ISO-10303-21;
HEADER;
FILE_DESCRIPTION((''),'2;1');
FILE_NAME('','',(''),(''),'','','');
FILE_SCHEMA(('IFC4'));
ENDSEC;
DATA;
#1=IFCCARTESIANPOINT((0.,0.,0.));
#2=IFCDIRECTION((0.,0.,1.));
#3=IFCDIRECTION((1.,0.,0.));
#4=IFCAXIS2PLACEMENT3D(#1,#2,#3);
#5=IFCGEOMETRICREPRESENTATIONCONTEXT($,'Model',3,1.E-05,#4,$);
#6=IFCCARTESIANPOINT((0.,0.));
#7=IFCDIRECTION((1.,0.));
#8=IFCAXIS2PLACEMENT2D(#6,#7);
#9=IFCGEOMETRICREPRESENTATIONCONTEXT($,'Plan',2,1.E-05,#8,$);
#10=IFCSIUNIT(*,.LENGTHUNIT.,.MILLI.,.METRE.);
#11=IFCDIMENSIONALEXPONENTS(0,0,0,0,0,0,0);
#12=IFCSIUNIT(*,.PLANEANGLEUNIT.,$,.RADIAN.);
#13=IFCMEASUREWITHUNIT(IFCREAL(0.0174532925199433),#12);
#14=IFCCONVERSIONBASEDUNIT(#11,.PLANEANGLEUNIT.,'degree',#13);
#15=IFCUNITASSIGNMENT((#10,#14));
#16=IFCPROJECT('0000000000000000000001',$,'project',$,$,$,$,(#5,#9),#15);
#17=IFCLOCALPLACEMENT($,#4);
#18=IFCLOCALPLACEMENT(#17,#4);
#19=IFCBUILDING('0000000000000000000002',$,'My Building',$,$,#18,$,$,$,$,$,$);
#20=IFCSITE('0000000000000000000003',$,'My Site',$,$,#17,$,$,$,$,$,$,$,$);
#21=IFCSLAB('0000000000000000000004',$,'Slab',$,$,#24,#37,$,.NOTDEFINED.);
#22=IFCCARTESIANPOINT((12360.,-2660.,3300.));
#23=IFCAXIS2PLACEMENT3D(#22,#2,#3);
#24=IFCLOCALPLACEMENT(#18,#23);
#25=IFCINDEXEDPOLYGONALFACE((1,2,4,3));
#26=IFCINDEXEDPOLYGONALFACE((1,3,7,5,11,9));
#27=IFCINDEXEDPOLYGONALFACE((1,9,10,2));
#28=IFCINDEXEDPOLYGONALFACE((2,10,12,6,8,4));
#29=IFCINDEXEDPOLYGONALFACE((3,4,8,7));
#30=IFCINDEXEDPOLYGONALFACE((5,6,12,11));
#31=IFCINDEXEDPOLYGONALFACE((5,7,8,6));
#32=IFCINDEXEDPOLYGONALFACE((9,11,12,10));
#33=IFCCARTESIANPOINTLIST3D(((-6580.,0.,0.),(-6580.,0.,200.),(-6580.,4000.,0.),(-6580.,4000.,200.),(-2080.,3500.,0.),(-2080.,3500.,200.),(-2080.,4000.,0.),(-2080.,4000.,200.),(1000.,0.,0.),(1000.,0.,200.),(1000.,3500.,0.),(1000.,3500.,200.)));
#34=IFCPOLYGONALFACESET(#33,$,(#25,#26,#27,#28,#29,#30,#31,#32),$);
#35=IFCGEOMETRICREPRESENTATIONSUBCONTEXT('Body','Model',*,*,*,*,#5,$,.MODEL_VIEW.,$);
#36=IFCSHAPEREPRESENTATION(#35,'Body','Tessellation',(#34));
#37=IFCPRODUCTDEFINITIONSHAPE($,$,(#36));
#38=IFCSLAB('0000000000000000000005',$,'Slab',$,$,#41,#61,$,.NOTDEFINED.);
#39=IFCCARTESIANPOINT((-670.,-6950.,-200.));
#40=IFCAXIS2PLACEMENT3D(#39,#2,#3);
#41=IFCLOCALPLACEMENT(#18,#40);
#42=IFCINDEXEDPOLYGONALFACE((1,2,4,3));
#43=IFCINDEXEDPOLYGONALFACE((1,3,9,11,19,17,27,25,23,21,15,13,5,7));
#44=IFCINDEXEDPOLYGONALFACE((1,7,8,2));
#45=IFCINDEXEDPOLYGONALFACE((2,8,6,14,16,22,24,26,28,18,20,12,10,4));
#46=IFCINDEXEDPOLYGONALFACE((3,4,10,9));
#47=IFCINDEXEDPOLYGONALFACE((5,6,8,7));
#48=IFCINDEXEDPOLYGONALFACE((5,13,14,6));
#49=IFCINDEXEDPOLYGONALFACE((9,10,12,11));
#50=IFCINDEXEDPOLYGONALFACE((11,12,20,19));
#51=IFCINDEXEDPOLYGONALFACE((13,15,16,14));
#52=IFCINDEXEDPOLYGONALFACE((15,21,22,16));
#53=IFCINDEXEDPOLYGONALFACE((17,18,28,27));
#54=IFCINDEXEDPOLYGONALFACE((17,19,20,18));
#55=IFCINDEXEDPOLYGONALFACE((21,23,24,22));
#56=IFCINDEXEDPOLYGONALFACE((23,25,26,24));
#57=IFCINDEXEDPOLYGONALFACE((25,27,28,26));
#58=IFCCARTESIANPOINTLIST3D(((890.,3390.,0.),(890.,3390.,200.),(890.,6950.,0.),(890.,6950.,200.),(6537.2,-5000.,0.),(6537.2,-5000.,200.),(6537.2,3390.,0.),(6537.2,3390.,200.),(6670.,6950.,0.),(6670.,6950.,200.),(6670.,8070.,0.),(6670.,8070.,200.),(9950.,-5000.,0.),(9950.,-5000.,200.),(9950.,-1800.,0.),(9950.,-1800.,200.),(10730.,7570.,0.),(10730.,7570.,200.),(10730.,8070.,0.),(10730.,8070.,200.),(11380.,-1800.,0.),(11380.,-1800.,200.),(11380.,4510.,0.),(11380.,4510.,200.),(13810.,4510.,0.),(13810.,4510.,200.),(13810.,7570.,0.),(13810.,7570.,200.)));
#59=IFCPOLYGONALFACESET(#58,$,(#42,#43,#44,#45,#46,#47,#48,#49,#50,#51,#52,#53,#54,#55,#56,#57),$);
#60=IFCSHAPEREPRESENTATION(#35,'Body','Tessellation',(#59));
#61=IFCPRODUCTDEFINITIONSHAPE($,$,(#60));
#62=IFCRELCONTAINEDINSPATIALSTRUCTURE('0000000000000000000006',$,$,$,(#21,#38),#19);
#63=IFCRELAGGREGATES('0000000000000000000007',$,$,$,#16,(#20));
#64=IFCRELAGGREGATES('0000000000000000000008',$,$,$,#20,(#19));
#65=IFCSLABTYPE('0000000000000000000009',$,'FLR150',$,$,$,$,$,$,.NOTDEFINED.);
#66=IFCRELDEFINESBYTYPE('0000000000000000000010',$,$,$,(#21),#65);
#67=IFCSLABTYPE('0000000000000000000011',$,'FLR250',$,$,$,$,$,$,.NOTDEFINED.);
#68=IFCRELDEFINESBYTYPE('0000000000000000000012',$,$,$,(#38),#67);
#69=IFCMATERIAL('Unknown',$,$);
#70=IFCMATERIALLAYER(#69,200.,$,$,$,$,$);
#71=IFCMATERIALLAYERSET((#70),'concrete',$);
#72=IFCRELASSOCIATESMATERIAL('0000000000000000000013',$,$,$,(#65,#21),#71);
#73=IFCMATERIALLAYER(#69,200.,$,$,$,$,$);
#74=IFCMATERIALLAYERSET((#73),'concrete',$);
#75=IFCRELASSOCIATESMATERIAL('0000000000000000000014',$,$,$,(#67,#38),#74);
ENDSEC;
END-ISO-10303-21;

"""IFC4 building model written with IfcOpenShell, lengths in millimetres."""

from ifc_helpers import new_model, entity, si_unit, converted_unit, frame, origin_with_axes, origin_2d_with_axis, place, context, subcontext, project, spatial, line, indexed_curve, outline, extrude, material, layer, layer_set, layer_usage, type_object, element, save


model = new_model("IFC4")

# Units and contexts
model_context = context("Model", 3, precision=1e-05, world=origin_with_axes())
plan_context = context("Plan", 2, precision=1e-05, world=origin_2d_with_axis())
body_context_1 = subcontext(model_context, "Body", "Model", "MODEL_VIEW")
ifc_project = project(units=[si_unit("LENGTHUNIT", "METRE", prefix="MILLI"), converted_unit("PLANEANGLEUNIT", "degree", entity("IfcReal", 0.0174532925199433), si_unit("PLANEANGLEUNIT", "RADIAN"), dimensions=[0, 0, 0, 0, 0, 0, 0])], contexts=[model_context, plan_context])

# Site, building
site_placement = place(None, origin_with_axes())
site = spatial("IfcSite", under=ifc_project, at=site_placement, Name="My Site")
building_placement = place(site_placement, origin_with_axes())
building = spatial("IfcBuilding", under=site, at=building_placement, Name="My Building")

# Slabs
ifc_material_1 = material(Name="Unknown")
ifc_layer_1 = layer(ifc_material_1, 200.0)
ifc_layer_set_1 = layer_set([ifc_layer_1], Name="concrete")
ifc_layer_usage_1 = layer_usage(ifc_layer_set_1, "AXIS3", "POSITIVE", 0.0)
slab_type_1 = type_object("IfcSlabType", Name="FLR150", PredefinedType="NOTDEFINED", material=ifc_layer_set_1)
slab_1_placement = place(building_placement, frame((12360.0, -2660.0, 3300.0), z_axis=(0.0, 0.0, 1.0), x_axis=(1.0, 0.0, 0.0)))
element("IfcSlab", 1, at=slab_1_placement, inside=building, type_object=slab_type_1, material=ifc_layer_usage_1, Name="Slab", PredefinedType="NOTDEFINED", context=body_context_1, shape_type="SweptSolid", body=[
    extrude(outline(indexed_curve([(-6580.0, 0.0), (1000.0, 0.0), (1000.0, 3500.0), (-6580.0, 4000.0), (-2080.0, 3500.0), (-2080.0, 4000.0)], segments=[line(6, 5), line(5, 3), line(3, 2), line(2, 1), line(1, 4), line(4, 6)], self_intersect=False)), None, (0.0, 0.0, 1.0), 200.0),
])
ifc_layer_2 = layer(ifc_material_1, 200.0)
ifc_layer_set_2 = layer_set([ifc_layer_2], Name="concrete")
ifc_layer_usage_2 = layer_usage(ifc_layer_set_2, "AXIS3", "POSITIVE", 0.0)
slab_type_2 = type_object("IfcSlabType", Name="FLR250", PredefinedType="NOTDEFINED", material=ifc_layer_set_2)
slab_2_placement = place(building_placement, frame((-670.0, -6950.0, -200.0), z_axis=(0.0, 0.0, 1.0), x_axis=(1.0, 0.0, 0.0)))
element("IfcSlab", 2, at=slab_2_placement, inside=building, type_object=slab_type_2, material=ifc_layer_usage_2, Name="Slab", PredefinedType="NOTDEFINED", context=body_context_1, shape_type="SweptSolid", body=[
    extrude(outline(indexed_curve([(6670.0, 6950.0), (890.0, 6950.0), (890.0, 3390.0), (6537.2, 3390.0), (6537.2, -5000.0), (9950.0, -5000.0), (9950.0, -1800.0), (11380.0, -1800.0), (11380.0, 4510.0), (13810.0, 4510.0), (13810.0, 7570.0), (10730.0, 7570.0), (10730.0, 8070.0), (6670.0, 8070.0)], segments=[line(1, 14), line(14, 13), line(13, 12), line(12, 11), line(11, 10), line(10, 9), line(9, 8), line(8, 7), line(7, 6), line(6, 5), line(5, 4), line(4, 3), line(3, 2), line(2, 1)], self_intersect=False)), None, (0.0, 0.0, 1.0), 200.0),
])

save(model, "model.ifc")
